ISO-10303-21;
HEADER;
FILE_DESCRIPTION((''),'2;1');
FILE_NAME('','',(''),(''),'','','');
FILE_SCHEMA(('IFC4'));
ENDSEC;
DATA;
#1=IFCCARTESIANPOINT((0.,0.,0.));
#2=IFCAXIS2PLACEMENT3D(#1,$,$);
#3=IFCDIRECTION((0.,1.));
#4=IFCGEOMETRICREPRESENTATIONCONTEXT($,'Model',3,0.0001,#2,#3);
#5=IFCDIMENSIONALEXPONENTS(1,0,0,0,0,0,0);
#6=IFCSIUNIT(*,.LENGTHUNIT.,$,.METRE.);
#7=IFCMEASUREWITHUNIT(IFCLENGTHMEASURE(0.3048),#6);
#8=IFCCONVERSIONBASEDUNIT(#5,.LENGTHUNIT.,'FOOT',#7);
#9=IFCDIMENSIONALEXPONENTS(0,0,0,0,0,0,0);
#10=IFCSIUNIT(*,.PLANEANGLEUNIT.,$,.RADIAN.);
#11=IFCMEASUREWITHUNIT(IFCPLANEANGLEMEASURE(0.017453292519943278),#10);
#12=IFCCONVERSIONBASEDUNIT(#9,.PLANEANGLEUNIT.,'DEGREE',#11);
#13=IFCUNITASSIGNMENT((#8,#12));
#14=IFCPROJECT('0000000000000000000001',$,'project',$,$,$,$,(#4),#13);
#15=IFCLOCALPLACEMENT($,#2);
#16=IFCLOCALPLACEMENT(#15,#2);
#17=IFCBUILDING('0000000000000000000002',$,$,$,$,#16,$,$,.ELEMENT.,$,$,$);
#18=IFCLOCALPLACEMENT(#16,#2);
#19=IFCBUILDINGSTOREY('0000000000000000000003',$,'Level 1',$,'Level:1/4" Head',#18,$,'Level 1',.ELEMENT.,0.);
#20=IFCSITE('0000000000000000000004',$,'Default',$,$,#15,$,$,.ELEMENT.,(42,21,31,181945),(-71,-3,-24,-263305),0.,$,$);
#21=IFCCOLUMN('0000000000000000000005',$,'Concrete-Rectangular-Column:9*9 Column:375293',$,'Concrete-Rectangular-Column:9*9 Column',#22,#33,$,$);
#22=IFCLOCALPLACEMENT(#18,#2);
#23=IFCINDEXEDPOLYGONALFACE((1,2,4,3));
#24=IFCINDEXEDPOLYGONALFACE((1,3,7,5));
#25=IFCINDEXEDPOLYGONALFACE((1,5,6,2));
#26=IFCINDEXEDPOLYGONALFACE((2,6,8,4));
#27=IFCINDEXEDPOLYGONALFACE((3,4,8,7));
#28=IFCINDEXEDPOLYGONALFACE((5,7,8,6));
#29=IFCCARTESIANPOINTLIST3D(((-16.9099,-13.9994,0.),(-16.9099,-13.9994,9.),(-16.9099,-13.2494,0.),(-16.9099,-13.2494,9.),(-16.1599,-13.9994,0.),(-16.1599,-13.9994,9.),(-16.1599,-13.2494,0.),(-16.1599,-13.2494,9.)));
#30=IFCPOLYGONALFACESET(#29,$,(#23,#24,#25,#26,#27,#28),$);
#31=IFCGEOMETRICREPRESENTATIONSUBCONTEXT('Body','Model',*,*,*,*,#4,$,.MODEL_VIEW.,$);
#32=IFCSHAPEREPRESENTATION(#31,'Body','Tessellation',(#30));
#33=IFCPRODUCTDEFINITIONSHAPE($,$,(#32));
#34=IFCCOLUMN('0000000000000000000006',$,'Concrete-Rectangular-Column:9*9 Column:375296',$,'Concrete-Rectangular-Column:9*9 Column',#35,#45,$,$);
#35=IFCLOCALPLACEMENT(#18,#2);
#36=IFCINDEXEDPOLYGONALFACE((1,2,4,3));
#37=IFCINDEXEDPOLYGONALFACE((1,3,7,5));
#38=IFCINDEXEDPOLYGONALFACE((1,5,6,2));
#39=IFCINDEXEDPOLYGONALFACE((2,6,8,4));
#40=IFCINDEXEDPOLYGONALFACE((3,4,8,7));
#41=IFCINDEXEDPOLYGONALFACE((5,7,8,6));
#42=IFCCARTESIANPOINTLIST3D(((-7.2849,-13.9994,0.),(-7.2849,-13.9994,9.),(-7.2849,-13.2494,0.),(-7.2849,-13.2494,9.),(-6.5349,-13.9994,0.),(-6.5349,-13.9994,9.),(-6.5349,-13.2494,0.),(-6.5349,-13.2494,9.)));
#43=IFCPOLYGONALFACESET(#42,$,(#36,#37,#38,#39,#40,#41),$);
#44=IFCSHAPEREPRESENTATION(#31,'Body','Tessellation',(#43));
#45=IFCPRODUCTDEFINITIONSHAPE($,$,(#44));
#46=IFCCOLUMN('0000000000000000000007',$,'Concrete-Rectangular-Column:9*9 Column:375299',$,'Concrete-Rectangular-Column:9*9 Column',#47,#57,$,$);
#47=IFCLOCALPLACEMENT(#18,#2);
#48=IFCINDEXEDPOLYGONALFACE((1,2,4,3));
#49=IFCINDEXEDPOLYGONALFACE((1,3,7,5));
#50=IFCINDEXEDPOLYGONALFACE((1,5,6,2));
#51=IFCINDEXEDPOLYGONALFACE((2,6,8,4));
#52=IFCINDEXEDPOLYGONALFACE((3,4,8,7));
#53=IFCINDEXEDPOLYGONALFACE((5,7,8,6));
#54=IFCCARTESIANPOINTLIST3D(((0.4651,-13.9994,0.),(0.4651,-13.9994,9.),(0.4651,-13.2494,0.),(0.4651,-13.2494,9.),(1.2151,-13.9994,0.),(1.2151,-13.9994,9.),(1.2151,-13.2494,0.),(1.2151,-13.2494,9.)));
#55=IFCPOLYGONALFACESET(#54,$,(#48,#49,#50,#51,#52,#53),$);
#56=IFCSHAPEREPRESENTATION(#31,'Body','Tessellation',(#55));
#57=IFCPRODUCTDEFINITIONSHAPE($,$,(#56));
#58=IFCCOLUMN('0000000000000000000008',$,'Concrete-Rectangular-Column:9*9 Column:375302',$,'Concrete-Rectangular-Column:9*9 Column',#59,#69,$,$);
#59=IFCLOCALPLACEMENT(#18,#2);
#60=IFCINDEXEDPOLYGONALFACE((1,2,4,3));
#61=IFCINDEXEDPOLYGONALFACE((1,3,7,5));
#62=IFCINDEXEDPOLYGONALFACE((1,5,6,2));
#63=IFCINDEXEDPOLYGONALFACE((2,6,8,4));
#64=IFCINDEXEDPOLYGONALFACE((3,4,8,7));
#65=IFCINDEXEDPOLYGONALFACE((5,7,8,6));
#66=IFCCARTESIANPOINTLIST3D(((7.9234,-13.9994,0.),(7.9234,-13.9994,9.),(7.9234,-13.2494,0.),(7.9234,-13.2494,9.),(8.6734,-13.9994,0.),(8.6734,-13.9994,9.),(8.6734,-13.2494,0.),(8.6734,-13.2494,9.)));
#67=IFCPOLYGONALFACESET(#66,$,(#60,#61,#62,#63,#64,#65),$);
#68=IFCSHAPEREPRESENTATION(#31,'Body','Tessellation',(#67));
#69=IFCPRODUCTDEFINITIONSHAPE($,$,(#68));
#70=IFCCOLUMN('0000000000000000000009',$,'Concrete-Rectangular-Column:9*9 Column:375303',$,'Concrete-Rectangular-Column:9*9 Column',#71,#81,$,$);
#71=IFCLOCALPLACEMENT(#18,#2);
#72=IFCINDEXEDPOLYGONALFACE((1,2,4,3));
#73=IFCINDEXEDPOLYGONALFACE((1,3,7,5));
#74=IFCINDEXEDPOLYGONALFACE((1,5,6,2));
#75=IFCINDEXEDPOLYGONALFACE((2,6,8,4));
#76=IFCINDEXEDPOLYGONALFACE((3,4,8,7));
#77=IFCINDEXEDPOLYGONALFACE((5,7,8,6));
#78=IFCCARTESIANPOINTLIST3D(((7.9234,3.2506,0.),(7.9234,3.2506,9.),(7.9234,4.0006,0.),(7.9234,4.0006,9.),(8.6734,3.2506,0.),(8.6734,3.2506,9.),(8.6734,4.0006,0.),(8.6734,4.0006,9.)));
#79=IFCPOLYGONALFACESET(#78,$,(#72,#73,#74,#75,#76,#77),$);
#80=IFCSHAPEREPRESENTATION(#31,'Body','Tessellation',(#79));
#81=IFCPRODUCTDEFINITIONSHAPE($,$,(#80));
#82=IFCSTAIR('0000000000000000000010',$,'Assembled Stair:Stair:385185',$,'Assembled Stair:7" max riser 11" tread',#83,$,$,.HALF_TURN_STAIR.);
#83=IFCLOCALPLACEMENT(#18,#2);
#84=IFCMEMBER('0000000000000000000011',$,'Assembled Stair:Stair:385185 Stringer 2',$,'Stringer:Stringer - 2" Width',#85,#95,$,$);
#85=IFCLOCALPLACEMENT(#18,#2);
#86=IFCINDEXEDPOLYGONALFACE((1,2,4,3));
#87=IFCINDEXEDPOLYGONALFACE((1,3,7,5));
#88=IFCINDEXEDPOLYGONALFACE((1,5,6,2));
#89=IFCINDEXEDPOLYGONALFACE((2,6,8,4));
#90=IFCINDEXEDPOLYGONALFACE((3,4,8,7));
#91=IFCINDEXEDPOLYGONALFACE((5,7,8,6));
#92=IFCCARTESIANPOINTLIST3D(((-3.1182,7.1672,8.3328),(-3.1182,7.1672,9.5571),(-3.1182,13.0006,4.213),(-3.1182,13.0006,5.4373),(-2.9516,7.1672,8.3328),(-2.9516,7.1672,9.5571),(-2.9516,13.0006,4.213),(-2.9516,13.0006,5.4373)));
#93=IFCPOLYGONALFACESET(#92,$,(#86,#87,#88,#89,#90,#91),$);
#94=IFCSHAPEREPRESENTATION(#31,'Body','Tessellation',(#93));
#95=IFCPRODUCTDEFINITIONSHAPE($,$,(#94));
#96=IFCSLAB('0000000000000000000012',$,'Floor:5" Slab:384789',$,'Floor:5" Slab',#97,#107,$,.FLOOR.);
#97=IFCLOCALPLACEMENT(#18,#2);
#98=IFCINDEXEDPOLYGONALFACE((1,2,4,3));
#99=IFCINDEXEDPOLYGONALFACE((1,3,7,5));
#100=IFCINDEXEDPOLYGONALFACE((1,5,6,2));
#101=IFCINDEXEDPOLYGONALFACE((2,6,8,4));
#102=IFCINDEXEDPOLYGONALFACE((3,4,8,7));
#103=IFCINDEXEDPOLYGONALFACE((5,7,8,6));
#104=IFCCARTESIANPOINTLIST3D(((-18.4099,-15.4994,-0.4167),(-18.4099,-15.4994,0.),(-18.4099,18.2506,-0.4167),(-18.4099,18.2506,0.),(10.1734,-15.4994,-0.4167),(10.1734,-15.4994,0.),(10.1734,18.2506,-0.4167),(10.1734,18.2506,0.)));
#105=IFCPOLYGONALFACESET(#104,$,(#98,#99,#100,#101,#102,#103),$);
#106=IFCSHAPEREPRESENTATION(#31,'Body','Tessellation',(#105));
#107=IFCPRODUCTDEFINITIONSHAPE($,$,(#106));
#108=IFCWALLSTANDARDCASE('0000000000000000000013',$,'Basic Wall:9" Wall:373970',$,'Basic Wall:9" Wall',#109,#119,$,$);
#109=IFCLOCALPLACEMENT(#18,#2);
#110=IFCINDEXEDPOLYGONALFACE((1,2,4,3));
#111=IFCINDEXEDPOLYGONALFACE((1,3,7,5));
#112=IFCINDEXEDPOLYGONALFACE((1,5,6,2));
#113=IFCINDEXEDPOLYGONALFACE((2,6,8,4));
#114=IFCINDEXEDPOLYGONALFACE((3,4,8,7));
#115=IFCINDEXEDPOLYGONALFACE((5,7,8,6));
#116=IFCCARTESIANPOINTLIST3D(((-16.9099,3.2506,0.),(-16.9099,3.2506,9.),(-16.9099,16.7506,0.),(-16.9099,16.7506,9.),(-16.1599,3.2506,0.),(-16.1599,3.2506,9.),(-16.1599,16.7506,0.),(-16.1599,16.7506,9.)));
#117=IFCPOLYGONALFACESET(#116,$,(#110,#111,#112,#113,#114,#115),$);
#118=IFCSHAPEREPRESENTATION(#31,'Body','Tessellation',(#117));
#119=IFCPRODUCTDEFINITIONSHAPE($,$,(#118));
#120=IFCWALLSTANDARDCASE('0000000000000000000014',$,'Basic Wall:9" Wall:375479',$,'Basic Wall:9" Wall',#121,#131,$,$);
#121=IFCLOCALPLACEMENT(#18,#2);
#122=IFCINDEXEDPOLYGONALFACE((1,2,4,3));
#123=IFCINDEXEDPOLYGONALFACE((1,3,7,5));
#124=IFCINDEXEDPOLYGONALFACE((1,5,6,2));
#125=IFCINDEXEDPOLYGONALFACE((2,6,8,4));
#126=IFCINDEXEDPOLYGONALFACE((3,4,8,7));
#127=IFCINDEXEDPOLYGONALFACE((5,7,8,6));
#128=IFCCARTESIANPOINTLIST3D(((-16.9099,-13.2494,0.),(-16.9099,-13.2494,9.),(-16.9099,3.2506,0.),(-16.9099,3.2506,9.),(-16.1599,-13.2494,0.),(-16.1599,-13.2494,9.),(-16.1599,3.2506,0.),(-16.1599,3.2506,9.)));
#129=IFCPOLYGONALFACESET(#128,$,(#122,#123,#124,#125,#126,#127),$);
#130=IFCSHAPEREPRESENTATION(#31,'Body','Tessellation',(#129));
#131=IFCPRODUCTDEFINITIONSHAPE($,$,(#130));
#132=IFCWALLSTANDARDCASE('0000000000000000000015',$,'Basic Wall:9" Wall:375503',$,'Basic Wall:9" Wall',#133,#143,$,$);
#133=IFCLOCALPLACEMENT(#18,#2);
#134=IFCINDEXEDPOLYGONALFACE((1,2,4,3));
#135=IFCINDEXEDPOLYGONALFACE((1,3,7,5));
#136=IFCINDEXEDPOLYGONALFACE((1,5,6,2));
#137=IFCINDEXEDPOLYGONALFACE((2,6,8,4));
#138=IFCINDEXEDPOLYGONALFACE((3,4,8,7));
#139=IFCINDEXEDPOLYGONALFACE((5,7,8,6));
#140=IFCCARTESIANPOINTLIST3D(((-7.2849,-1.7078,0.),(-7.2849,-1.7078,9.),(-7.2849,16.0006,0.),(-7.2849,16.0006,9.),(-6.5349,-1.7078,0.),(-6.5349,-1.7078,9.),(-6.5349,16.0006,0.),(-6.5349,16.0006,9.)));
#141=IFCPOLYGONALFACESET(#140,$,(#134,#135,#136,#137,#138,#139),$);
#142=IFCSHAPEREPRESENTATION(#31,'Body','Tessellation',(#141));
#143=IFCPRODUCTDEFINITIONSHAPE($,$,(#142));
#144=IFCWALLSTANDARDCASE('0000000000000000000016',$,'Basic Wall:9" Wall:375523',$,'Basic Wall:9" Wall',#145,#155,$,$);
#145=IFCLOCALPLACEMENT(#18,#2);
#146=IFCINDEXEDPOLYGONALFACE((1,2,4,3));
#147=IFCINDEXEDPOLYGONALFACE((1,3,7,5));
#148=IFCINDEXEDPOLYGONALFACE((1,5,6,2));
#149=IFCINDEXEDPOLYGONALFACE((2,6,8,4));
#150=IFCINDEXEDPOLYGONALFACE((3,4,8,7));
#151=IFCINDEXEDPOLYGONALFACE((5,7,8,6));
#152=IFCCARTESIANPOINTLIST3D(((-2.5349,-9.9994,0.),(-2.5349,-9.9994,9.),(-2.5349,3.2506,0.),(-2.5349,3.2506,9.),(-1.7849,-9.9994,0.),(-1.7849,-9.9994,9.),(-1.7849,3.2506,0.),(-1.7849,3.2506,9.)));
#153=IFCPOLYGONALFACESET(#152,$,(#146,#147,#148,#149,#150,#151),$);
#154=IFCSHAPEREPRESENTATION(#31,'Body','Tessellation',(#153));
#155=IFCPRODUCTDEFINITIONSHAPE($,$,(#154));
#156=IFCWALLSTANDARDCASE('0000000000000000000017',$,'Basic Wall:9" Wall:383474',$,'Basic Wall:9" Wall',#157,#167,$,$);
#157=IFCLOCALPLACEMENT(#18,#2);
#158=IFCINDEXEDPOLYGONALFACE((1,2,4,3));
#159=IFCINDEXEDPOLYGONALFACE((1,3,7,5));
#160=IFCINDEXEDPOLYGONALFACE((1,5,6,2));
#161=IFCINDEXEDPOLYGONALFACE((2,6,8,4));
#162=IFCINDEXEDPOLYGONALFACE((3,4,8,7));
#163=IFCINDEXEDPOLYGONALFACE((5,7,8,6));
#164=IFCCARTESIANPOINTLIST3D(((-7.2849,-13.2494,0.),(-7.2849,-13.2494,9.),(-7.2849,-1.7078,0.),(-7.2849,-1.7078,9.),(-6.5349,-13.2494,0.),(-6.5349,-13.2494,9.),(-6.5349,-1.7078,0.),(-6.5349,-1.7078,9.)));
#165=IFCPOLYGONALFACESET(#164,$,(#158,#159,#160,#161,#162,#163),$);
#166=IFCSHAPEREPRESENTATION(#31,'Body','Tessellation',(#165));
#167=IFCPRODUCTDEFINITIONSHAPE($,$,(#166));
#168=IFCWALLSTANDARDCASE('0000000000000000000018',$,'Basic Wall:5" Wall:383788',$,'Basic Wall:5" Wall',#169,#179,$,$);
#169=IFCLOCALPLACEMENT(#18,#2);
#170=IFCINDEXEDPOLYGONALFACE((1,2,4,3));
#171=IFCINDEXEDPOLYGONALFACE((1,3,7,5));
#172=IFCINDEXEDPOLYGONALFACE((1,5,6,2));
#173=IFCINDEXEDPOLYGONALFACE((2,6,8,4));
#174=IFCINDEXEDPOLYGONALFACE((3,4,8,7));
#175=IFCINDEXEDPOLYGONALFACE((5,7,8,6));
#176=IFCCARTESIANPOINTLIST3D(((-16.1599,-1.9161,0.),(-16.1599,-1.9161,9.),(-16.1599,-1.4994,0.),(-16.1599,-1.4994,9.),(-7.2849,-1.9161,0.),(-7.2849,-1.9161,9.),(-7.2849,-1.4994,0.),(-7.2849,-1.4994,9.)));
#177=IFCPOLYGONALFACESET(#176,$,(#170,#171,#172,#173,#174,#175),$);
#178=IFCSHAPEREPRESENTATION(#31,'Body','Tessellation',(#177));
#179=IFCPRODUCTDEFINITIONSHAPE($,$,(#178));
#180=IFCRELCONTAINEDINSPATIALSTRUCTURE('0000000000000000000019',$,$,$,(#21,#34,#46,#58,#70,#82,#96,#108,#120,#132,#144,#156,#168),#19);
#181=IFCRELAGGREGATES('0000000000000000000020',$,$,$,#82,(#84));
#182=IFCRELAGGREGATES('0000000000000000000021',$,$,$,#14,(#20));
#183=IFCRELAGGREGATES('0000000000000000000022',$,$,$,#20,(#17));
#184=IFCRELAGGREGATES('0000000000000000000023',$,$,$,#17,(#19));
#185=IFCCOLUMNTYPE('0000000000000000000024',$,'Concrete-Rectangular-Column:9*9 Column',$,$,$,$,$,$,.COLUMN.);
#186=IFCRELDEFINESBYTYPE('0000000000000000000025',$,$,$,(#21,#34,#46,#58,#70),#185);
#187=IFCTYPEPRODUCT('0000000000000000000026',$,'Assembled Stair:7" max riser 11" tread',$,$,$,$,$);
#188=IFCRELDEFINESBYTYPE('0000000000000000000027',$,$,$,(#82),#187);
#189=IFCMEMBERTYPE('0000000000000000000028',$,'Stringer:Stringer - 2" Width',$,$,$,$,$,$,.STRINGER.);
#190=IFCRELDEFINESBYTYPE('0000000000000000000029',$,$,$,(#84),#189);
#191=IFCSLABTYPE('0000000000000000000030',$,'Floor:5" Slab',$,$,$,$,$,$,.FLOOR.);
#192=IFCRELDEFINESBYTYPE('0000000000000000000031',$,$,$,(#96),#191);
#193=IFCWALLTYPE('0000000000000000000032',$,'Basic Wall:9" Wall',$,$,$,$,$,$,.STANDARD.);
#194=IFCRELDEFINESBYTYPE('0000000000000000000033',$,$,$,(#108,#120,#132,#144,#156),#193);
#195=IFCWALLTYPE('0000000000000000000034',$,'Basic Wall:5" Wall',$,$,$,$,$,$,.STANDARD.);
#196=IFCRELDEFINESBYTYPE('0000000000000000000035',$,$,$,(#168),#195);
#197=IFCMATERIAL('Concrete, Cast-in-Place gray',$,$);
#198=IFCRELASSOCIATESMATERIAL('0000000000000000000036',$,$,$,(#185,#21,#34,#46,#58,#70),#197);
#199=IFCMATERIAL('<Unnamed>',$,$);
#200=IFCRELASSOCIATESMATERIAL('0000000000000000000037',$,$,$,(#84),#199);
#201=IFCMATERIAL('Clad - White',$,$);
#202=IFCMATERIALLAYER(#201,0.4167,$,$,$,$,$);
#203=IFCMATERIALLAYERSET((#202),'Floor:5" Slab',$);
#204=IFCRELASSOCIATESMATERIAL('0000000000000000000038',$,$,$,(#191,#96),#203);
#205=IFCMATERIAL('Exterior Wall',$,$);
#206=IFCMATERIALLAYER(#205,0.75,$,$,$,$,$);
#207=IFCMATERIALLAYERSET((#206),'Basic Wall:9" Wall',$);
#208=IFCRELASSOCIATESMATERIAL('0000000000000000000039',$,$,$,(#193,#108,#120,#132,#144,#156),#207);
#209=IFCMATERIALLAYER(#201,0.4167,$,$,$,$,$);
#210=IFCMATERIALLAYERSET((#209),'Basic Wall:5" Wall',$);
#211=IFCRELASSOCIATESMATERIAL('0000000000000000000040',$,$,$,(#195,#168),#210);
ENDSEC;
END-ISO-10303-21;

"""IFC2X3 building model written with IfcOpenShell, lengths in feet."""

from ifc_helpers import new_model, entity, si_unit, converted_unit, direction, frame, frame_2d, origin, origin_2d_with_axis, place, context, subcontext, project, spatial, polyline, rectangle, outline, extrude, clip, bounded_halfspace, source, transform, mapped, material, layer, layer_set, layer_usage, type_object, type_shapes, element, aggregate, save


model = new_model("IFC2X3")

# Units and contexts
model_context = context("Model", 3, precision=0.0001, world=origin(), true_north=direction((0.0, 1.0)))
body_context = subcontext(model_context, "Body", "Model", "MODEL_VIEW")
ifc_project = project(units=[converted_unit("LENGTHUNIT", "FOOT", entity("IfcLengthMeasure", 0.3048), si_unit("LENGTHUNIT", "METRE"), dimensions=[1, 0, 0, 0, 0, 0, 0]), converted_unit("PLANEANGLEUNIT", "DEGREE", entity("IfcPlaneAngleMeasure", 0.017453292519943278), si_unit("PLANEANGLEUNIT", "RADIAN"), dimensions=[0, 0, 0, 0, 0, 0, 0])], contexts=[model_context])

# Site, building, storey
site_placement = place(None, origin())
site = spatial("IfcSite", under=ifc_project, at=site_placement, Name="Default", CompositionType="ELEMENT", RefLatitude=(42, 21, 31, 181945), RefLongitude=(-71, -3, -24, -263305), RefElevation=0.0)
building_placement = place(site_placement, origin())
building = spatial("IfcBuilding", under=site, at=building_placement, CompositionType="ELEMENT")
storey_placement = place(building_placement, origin())
storey = spatial("IfcBuildingStorey", under=building, at=storey_placement, Name="Level 1", ObjectType="Level:1/4\" Head", LongName="Level 1", CompositionType="ELEMENT", Elevation=0.0)

# Columns
ifc_material_1 = material(Name="Concrete, Cast-in-Place gray")
column_type = type_object("IfcColumnType", Name="Concrete-Rectangular-Column:9*9 Column", PredefinedType="COLUMN", material=ifc_material_1)
shared_shape = source(origin(), body_context, "Body", "SweptSolid", [
    extrude(rectangle(XDim=0.75, YDim=0.75, at=origin_2d_with_axis()), frame((0.0, 0.0, 0.0), z_axis=(0.0, 0.0, 1.0), x_axis=(-1.0, 0.0, 0.0)), (0.0, 0.0, 1.0), 9.0),
])
type_shapes(column_type, [shared_shape])
for number, where, name in (
    (1, (-16.5349, -13.6244, 0.0), "Concrete-Rectangular-Column:9*9 Column:375293"),
    (2, (-6.9099, -13.6244, 0.0), "Concrete-Rectangular-Column:9*9 Column:375296"),
    (3, (0.8401, -13.6244, 0.0), "Concrete-Rectangular-Column:9*9 Column:375299"),
    (4, (8.2984, -13.6244, 0.0), "Concrete-Rectangular-Column:9*9 Column:375302"),
    (5, (8.2984, 3.6256, 0.0), "Concrete-Rectangular-Column:9*9 Column:375303"),
):
    element("IfcColumn", number, at=place(storey_placement, frame(where)), inside=storey, type_object=column_type, material=ifc_material_1, Name=name, ObjectType="Concrete-Rectangular-Column:9*9 Column", context=body_context, shape_type="MappedRepresentation", body=[
        mapped(shared_shape, transform((0.0, 0.0, 0.0), scale=1.0)),
    ])

# Stair, member
type_product = type_object("IfcTypeProduct", Name="Assembled Stair:7\" max riser 11\" tread")
stair_placement = place(storey_placement, origin())
stair = element("IfcStair", 6, at=stair_placement, inside=storey, type_object=type_product, Name="Assembled Stair:Stair:385185", ObjectType="Assembled Stair:7\" max riser 11\" tread", ShapeType="HALF_TURN_STAIR")
ifc_material_2 = material(Name="<Unnamed>")
member_type = type_object("IfcMemberType", Name="Stringer:Stringer - 2\" Width", PredefinedType="STRINGER")
member_1_placement = place(stair_placement, origin())
member_1 = element("IfcMember", 7, at=member_1_placement, type_object=member_type, material=ifc_material_2, Name="Assembled Stair:Stair:385185 Stringer 2", ObjectType="Stringer:Stringer - 2\" Width", context=body_context, shape_type="SweptSolid", body=[
    extrude(outline(polyline([(-3.2176, -0.5), (3.9239, -0.5), (3.2176, 0.5), (-3.9239, 0.5), (-3.2176, -0.5)])), frame((-3.1182, 10.0839, 6.8851), z_axis=(1.0, 0.0, 0.0), x_axis=(0.0, -0.816826, 0.576884)), (0.0, 0.0, 1.0), 0.1667),
])

# Slab
ifc_material_3 = material(Name="Clad - White")
ifc_layer_1 = layer(ifc_material_3, 0.4167)
ifc_layer_set_1 = layer_set([ifc_layer_1], Name="Floor:5\" Slab")
ifc_layer_usage_1 = layer_usage(ifc_layer_set_1, "AXIS3", "POSITIVE", 0.0)
slab_type = type_object("IfcSlabType", Name="Floor:5\" Slab", PredefinedType="FLOOR", material=ifc_layer_set_1)
slab_placement = place(storey_placement, origin())
element("IfcSlab", 8, at=slab_placement, inside=storey, type_object=slab_type, material=ifc_layer_usage_1, Name="Floor:5\" Slab:384789", ObjectType="Floor:5\" Slab", PredefinedType="FLOOR", context=body_context, shape_type="SweptSolid", body=[
    extrude(rectangle(XDim=33.75, YDim=28.5833, at=origin_2d_with_axis()), frame((-4.1182, 1.3756, 0.0), z_axis=(0.0, 0.0, -1.0), x_axis=(0.0, 1.0, 0.0)), (0.0, 0.0, 1.0), 0.4167),
])

# Walls
ifc_material_4 = material(Name="Exterior Wall")
ifc_layer_2 = layer(ifc_material_4, 0.75)
ifc_layer_set_2 = layer_set([ifc_layer_2], Name="Basic Wall:9\" Wall")
ifc_layer_usage_2 = layer_usage(ifc_layer_set_2, "AXIS2", "NEGATIVE", 0.375)
wall_type_1 = type_object("IfcWallType", Name="Basic Wall:9\" Wall", PredefinedType="STANDARD", material=ifc_layer_set_2)
wall_1_placement = place(storey_placement, frame((-16.5349, 3.2506, 0.0), z_axis=(0.0, 0.0, 1.0), x_axis=(0.0, 1.0, 0.0)))
element("IfcWallStandardCase", 9, at=wall_1_placement, inside=storey, type_object=wall_type_1, material=ifc_layer_usage_2, Name="Basic Wall:9\" Wall:373970", ObjectType="Basic Wall:9\" Wall", context=body_context, shape_type="Clipping", body=[
    clip(extrude(rectangle(XDim=13.5, YDim=0.75, at=frame_2d((6.75, 0.0), x_axis=(-1.0, 0.0))), origin(), (0.0, 0.0, 1.0), 9.0), bounded_halfspace(frame((0.0, -0.375, 9.0), z_axis=(0.0, 0.0, -1.0), x_axis=(-1.0, 0.0, 0.0)), True, frame((0.0, -0.375, 9.0)), polyline([(0.0, 0.0), (0.75, 0.0), (12.75, 0.0), (13.5, 0.0), (13.5, 0.75), (0.0, 0.75), (0.0, 0.0)]))),
])
wall_2_placement = place(storey_placement, frame((-16.5349, -13.2494, 0.0), z_axis=(0.0, 0.0, 1.0), x_axis=(0.0, 1.0, 0.0)))
element("IfcWallStandardCase", 10, at=wall_2_placement, inside=storey, type_object=wall_type_1, material=ifc_layer_usage_2, Name="Basic Wall:9\" Wall:375479", ObjectType="Basic Wall:9\" Wall", context=body_context, shape_type="Clipping", body=[
    clip(extrude(rectangle(XDim=16.5, YDim=0.75, at=frame_2d((8.25, 0.0), x_axis=(-1.0, 0.0))), origin(), (0.0, 0.0, 1.0), 9.0), bounded_halfspace(frame((0.0, -0.375, 9.0), z_axis=(0.0, 0.0, -1.0), x_axis=(-1.0, 0.0, 0.0)), True, frame((0.0, -0.375, 9.0)), polyline([(0.0, 0.0), (11.3333, 0.0), (11.75, 0.0), (16.5, 0.0), (16.5, 0.75), (0.0, 0.75), (0.0, 0.0)]))),
])
wall_3_placement = place(storey_placement, frame((-6.9099, -1.7078, 0.0), z_axis=(0.0, 0.0, 1.0), x_axis=(0.0, 1.0, 0.0)))
element("IfcWallStandardCase", 11, at=wall_3_placement, inside=storey, type_object=wall_type_1, material=ifc_layer_usage_2, Name="Basic Wall:9\" Wall:375503", ObjectType="Basic Wall:9\" Wall", context=body_context, shape_type="Clipping", body=[
    clip(extrude(rectangle(XDim=17.7083, YDim=0.75, at=frame_2d((8.8542, 0.0), x_axis=(-1.0, 0.0))), origin(), (0.0, 0.0, 1.0), 9.0), bounded_halfspace(frame((0.0, -0.375, 9.0), z_axis=(0.0, 0.0, -1.0), x_axis=(-1.0, 0.0, 0.0)), True, frame((0.0, -0.375, 9.0)), polyline([(0.0, 0.0), (8.875, 0.0), (17.7083, 0.0), (17.7083, 0.75), (5.7083, 0.75), (4.9583, 0.75), (0.2083, 0.75), (0.0, 0.75), (0.0, 0.0)]))),
])
wall_4_placement = place(storey_placement, frame((-2.1599, 3.2506, 0.0), z_axis=(0.0, 0.0, 1.0), x_axis=(0.0, -1.0, 0.0)))
element("IfcWallStandardCase", 12, at=wall_4_placement, inside=storey, type_object=wall_type_1, material=ifc_layer_usage_2, Name="Basic Wall:9\" Wall:375523", ObjectType="Basic Wall:9\" Wall", context=body_context, shape_type="Clipping", body=[
    clip(extrude(rectangle(XDim=13.25, YDim=0.75, at=frame_2d((6.625, 0.0), x_axis=(-1.0, 0.0))), origin(), (0.0, 0.0, 1.0), 9.0), bounded_halfspace(frame((0.0, -0.375, 9.0), z_axis=(0.0, 0.0, -1.0), x_axis=(1.0, 0.0, 0.0)), True, frame((0.0, -0.375, 9.0)), polyline([(0.0, 0.0), (13.25, 0.0), (13.25, 0.75), (12.8333, 0.75), (0.0, 0.75), (0.0, 0.0)]))),
])
wall_5_placement = place(storey_placement, frame((-6.9099, -1.7078, 0.0), z_axis=(0.0, 0.0, 1.0), x_axis=(0.0, -1.0, 0.0)))
element("IfcWallStandardCase", 13, at=wall_5_placement, inside=storey, type_object=wall_type_1, material=ifc_layer_usage_2, Name="Basic Wall:9\" Wall:383474", ObjectType="Basic Wall:9\" Wall", context=body_context, shape_type="Clipping", body=[
    clip(extrude(rectangle(XDim=11.5417, YDim=0.75, at=frame_2d((5.7708, 0.0), x_axis=(-1.0, 0.0))), origin(), (0.0, 0.0, 1.0), 9.0), bounded_halfspace(frame((0.0, -0.375, 9.0), z_axis=(0.0, 0.0, -1.0), x_axis=(1.0, 0.0, 0.0)), True, frame((0.0, -0.375, 9.0)), polyline([(0.0, 0.0), (0.2083, 0.0), (11.5417, 0.0), (11.5417, 0.75), (0.0, 0.75), (0.0, 0.0)]))),
])
ifc_layer_3 = layer(ifc_material_3, 0.4167)
ifc_layer_set_3 = layer_set([ifc_layer_3], Name="Basic Wall:5\" Wall")
ifc_layer_usage_3 = layer_usage(ifc_layer_set_3, "AXIS2", "NEGATIVE", 0.2083)
wall_type_2 = type_object("IfcWallType", Name="Basic Wall:5\" Wall", PredefinedType="STANDARD", material=ifc_layer_set_3)
wall_6_placement = place(storey_placement, frame((-16.1599, -1.7078, 0.0)))
element("IfcWallStandardCase", 14, at=wall_6_placement, inside=storey, type_object=wall_type_2, material=ifc_layer_usage_3, Name="Basic Wall:5\" Wall:383788", ObjectType="Basic Wall:5\" Wall", context=body_context, shape_type="Clipping", body=[
    clip(extrude(rectangle(XDim=8.875, YDim=0.4167, at=frame_2d((4.4375, 0.0), x_axis=(-1.0, 0.0))), origin(), (0.0, 0.0, 1.0), 9.0), bounded_halfspace(frame((0.0, -0.2083, 9.0), z_axis=(0.0, 0.0, -1.0), x_axis=(0.0, -1.0, 0.0)), True, frame((0.0, -0.2083, 9.0)), polyline([(0.0, 0.0), (8.875, 0.0), (8.875, 0.2083), (8.875, 0.4167), (0.0, 0.4167), (0.0, 0.0)]))),
])

aggregate(stair, [member_1])

save(model, "model.ifc")
